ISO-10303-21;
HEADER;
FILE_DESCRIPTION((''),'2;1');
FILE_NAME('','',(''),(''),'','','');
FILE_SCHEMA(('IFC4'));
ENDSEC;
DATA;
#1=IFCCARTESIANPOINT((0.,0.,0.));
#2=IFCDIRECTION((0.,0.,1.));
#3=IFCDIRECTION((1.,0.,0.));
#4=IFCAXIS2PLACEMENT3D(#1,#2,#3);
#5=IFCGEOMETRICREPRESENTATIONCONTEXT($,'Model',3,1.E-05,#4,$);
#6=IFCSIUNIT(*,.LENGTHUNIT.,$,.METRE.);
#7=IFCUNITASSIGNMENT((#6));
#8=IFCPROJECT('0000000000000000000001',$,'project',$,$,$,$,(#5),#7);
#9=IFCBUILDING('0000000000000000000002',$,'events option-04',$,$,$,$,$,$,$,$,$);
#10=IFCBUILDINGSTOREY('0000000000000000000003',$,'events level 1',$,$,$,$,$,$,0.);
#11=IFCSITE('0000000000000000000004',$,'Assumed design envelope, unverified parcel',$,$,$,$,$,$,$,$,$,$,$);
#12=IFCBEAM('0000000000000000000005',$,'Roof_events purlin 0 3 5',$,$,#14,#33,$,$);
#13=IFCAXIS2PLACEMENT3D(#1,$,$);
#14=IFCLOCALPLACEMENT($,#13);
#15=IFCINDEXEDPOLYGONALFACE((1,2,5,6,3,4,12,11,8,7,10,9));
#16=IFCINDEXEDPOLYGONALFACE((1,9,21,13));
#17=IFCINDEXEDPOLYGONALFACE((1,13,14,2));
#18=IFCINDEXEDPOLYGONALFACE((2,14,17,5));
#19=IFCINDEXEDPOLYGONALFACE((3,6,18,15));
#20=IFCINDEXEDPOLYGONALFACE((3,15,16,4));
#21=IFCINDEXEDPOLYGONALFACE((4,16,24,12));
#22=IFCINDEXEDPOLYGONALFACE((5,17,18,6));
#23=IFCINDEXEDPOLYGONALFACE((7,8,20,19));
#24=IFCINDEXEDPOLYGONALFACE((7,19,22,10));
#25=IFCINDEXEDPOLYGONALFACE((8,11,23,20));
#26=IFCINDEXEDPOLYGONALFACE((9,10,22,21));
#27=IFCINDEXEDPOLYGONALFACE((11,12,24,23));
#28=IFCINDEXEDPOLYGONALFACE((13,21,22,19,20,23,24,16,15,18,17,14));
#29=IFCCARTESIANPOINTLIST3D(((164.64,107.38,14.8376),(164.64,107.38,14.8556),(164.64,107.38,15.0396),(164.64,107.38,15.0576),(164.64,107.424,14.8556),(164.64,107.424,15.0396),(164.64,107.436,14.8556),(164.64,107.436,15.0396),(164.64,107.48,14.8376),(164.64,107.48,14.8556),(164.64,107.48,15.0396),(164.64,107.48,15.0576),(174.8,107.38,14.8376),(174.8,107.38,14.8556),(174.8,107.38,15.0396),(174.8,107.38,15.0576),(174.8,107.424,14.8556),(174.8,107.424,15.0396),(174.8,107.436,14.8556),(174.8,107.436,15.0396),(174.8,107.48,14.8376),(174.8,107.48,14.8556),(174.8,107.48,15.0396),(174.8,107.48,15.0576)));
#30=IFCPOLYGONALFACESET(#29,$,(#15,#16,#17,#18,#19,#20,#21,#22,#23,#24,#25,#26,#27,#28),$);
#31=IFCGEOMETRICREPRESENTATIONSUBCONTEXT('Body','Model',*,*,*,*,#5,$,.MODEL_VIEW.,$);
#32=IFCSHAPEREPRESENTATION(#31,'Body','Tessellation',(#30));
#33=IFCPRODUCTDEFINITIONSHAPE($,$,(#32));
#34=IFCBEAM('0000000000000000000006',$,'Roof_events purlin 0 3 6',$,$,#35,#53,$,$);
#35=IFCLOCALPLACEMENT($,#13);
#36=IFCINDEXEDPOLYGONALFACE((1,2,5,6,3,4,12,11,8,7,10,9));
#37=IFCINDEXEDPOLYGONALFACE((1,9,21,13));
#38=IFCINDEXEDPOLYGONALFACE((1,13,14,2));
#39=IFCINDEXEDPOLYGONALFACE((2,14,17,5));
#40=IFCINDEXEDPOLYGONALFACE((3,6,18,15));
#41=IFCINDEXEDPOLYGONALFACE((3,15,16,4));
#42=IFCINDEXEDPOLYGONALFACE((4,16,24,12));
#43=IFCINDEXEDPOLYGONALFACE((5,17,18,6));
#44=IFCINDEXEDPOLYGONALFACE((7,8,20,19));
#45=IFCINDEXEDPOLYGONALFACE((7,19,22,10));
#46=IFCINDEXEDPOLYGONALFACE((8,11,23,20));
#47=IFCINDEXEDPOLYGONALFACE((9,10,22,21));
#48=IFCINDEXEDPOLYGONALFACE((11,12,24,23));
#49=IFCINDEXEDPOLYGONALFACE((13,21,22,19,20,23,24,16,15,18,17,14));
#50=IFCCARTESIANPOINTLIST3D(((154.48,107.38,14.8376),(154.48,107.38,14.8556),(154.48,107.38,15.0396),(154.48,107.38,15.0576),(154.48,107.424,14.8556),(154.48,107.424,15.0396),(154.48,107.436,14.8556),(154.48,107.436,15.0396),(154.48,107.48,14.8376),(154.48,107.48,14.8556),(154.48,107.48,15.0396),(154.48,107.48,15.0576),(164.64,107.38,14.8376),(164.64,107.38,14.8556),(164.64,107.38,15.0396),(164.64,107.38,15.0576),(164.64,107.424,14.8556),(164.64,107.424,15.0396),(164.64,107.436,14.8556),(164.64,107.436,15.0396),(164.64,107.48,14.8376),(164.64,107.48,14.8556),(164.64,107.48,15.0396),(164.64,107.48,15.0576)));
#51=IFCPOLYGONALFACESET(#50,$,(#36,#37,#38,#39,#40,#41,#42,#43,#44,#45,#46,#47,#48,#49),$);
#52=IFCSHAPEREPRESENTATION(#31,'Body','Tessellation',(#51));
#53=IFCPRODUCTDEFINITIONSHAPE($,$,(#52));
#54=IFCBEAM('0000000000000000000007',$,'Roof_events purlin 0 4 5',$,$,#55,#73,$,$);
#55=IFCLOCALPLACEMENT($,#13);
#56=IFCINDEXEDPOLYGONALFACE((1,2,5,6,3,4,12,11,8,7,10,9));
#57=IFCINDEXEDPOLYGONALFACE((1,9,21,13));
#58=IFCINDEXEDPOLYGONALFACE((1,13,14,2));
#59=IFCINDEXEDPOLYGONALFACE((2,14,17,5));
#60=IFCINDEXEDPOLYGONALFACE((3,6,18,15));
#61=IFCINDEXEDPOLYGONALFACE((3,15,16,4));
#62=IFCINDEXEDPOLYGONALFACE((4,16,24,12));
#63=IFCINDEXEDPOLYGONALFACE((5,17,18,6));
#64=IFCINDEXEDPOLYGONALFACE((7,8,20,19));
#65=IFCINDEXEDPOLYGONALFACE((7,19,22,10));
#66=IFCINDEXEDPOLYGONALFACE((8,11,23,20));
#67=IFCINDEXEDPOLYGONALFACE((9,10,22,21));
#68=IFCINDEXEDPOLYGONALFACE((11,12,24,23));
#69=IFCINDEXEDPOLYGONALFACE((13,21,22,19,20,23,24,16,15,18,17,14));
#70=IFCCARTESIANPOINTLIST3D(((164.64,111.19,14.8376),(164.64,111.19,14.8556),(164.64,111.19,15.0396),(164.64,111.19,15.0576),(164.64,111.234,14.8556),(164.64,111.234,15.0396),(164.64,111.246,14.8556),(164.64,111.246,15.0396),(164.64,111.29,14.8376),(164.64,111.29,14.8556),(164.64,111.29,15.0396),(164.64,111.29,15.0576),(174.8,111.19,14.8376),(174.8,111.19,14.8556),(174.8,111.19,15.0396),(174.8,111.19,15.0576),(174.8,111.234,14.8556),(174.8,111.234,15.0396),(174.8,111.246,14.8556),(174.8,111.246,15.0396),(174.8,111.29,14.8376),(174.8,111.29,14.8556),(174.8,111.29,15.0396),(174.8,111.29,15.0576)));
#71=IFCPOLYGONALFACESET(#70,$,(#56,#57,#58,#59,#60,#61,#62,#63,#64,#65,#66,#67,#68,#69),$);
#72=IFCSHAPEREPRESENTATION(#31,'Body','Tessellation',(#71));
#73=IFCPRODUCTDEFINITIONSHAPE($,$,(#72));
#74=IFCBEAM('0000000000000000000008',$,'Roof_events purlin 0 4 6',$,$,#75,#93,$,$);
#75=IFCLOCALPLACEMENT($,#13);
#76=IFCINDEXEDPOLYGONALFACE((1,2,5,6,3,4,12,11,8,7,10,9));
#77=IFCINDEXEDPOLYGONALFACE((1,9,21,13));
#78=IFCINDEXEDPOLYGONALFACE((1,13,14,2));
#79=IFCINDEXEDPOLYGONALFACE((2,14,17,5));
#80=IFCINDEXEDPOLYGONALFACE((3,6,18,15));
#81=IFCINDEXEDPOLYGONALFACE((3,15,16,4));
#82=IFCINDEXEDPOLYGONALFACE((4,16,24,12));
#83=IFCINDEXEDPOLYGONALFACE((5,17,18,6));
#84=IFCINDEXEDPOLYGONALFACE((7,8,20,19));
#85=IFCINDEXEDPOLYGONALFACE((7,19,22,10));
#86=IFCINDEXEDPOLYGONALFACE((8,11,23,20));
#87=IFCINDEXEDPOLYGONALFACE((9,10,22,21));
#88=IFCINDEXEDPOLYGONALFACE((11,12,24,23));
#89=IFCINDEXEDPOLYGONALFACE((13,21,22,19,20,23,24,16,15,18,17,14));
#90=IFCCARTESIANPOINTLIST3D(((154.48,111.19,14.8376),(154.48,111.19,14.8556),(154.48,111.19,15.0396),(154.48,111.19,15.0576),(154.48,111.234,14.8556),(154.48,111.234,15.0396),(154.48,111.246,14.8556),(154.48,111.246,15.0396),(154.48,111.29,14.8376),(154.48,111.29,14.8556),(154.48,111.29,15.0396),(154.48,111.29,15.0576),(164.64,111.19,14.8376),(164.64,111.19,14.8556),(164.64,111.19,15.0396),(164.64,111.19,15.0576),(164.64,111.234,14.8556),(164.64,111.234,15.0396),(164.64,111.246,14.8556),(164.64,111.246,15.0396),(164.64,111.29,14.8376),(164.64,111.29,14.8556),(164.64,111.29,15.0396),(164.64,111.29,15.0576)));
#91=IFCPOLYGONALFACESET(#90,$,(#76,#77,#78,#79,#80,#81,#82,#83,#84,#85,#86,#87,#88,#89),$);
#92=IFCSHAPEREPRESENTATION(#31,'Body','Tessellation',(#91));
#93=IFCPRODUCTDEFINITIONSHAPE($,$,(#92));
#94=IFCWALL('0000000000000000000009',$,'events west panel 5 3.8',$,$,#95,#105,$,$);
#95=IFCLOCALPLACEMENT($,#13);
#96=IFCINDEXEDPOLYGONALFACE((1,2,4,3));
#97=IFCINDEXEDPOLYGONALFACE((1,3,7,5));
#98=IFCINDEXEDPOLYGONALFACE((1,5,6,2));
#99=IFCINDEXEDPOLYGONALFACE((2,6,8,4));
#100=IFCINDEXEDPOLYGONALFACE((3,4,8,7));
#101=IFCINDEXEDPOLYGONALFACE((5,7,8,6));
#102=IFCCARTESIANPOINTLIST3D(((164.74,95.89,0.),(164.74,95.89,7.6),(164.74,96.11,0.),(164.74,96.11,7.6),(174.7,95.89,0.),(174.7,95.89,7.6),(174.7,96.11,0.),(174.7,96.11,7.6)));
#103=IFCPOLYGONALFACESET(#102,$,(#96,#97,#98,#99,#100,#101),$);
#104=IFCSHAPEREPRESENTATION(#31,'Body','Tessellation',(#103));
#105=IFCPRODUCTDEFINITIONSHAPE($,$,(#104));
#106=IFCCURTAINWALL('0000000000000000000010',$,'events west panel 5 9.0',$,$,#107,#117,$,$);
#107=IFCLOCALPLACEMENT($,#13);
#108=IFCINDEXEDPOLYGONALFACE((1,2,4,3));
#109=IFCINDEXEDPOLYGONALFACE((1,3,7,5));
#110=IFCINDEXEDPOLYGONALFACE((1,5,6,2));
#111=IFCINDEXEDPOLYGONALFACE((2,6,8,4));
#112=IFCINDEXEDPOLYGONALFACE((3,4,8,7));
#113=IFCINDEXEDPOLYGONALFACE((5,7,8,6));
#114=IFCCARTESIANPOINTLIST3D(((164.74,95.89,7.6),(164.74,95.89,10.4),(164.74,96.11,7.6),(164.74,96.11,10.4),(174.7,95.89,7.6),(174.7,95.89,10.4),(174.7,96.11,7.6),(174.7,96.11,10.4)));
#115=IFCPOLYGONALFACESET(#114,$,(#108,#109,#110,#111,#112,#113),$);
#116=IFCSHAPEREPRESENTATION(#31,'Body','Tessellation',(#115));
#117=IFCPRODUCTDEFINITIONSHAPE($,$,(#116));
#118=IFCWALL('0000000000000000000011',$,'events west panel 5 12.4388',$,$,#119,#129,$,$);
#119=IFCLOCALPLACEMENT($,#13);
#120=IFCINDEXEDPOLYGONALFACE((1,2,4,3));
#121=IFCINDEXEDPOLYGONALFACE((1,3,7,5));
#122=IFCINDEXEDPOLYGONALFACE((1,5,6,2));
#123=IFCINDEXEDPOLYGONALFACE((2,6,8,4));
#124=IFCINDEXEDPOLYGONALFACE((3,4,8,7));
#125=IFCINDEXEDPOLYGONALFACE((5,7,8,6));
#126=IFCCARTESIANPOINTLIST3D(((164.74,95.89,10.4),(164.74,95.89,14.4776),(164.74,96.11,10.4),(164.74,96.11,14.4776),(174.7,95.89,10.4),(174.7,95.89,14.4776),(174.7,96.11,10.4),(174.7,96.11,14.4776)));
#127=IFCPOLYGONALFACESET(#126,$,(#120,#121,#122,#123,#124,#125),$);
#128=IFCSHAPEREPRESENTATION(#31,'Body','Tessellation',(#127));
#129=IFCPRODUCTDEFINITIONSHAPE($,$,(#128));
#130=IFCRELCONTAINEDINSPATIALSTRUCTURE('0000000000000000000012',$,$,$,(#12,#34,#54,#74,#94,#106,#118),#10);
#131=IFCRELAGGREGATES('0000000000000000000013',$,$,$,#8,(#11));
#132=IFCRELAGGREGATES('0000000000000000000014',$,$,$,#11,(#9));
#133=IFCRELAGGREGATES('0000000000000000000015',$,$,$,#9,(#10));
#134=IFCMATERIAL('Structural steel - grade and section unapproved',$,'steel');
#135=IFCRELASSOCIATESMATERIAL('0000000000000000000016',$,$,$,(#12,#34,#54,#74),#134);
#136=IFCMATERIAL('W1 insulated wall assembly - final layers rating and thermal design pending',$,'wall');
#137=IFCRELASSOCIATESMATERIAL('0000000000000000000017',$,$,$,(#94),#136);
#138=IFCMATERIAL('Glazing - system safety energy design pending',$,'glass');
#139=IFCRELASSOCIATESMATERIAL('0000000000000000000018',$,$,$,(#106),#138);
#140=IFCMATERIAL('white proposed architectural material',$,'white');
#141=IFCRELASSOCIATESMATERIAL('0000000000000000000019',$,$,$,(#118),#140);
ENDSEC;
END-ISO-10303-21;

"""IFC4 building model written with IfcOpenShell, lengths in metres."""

from ifc_helpers import new_model, si_unit, frame, origin_with_axes, place, context, subcontext, project, spatial, rectangle, i_section, extrude, material, element, save


model = new_model("IFC4")

# Units and contexts
model_context = context("Model", 3, precision=1e-05, world=origin_with_axes())
body_context = subcontext(model_context, "Body", "Model", "MODEL_VIEW")
ifc_project = project(units=[si_unit("LENGTHUNIT", "METRE")], contexts=[model_context])

# Site, building, storey
site = spatial("IfcSite", under=ifc_project, Name="Assumed design envelope, unverified parcel")
building = spatial("IfcBuilding", under=site, Name="events option-04")
storey = spatial("IfcBuildingStorey", under=building, Name="events level 1", Elevation=0.0)

# Shared definitions
ifc_material_1 = material(Name="Structural steel - grade and section unapproved", Category="steel")

# Beams
for number, where, z_axis, x_axis, name in (
    (1, (174.8, 107.43, 14.9476), (-1.0, 0.0, 0.0), (0.0, -1.0, 0.0), "Roof_events purlin 0 3 5"),
    (2, (164.64, 107.43, 14.9476), (-1.0, 0.0, 0.0), (0.0, -1.0, 0.0), "Roof_events purlin 0 3 6"),
    (3, (174.8, 111.24, 14.9476), (-1.0, 0.0, 0.0), (0.0, -1.0, 0.0), "Roof_events purlin 0 4 5"),
    (4, (164.64, 111.24, 14.9476), (-1.0, 0.0, 0.0), (0.0, -1.0, 0.0), "Roof_events purlin 0 4 6"),
):
    element("IfcBeam", number, at=place(None, frame(where, z_axis=z_axis, x_axis=x_axis)), inside=storey, material=ifc_material_1, Name=name, context=body_context, shape_type="SweptSolid", body=[
        extrude(i_section(OverallWidth=0.1, OverallDepth=0.22, WebThickness=0.012, FlangeThickness=0.018, FilletRadius=0.0), origin_with_axes(), (0.0, 0.0, 1.0), 10.16),
    ])

# Wall
ifc_material_2 = material(Name="W1 insulated wall assembly - final layers rating and thermal design pending", Category="wall")
wall_1_placement = place(None, frame((169.72, 96.0, 0.0), z_axis=(0.0, 0.0, 1.0), x_axis=(0.0, 1.0, 0.0)))
element("IfcWall", 5, at=wall_1_placement, inside=storey, material=ifc_material_2, Name="events west panel 5 3.8", context=body_context, shape_type="SweptSolid", body=[
    extrude(rectangle(XDim=0.22, YDim=9.96), origin_with_axes(), (0.0, 0.0, 1.0), 7.6),
])

# Curtain wall
ifc_material_3 = material(Name="Glazing - system safety energy design pending", Category="glass")
curtain_wall_placement = place(None, frame((169.72, 96.0, 7.6), z_axis=(0.0, 0.0, 1.0), x_axis=(0.0, 1.0, 0.0)))
element("IfcCurtainWall", 6, at=curtain_wall_placement, inside=storey, material=ifc_material_3, Name="events west panel 5 9.0", context=body_context, shape_type="SweptSolid", body=[
    extrude(rectangle(XDim=0.22, YDim=9.96), origin_with_axes(), (0.0, 0.0, 1.0), 2.8),
])

# Wall
ifc_material_4 = material(Name="white proposed architectural material", Category="white")
wall_2_placement = place(None, frame((169.72, 96.0, 10.4), z_axis=(0.0, 0.0, 1.0), x_axis=(0.0, 1.0, 0.0)))
element("IfcWall", 7, at=wall_2_placement, inside=storey, material=ifc_material_4, Name="events west panel 5 12.4388", context=body_context, shape_type="SweptSolid", body=[
    extrude(rectangle(XDim=0.22, YDim=9.96), origin_with_axes(), (0.0, 0.0, 1.0), 4.0776),
])

save(model, "model.ifc")
